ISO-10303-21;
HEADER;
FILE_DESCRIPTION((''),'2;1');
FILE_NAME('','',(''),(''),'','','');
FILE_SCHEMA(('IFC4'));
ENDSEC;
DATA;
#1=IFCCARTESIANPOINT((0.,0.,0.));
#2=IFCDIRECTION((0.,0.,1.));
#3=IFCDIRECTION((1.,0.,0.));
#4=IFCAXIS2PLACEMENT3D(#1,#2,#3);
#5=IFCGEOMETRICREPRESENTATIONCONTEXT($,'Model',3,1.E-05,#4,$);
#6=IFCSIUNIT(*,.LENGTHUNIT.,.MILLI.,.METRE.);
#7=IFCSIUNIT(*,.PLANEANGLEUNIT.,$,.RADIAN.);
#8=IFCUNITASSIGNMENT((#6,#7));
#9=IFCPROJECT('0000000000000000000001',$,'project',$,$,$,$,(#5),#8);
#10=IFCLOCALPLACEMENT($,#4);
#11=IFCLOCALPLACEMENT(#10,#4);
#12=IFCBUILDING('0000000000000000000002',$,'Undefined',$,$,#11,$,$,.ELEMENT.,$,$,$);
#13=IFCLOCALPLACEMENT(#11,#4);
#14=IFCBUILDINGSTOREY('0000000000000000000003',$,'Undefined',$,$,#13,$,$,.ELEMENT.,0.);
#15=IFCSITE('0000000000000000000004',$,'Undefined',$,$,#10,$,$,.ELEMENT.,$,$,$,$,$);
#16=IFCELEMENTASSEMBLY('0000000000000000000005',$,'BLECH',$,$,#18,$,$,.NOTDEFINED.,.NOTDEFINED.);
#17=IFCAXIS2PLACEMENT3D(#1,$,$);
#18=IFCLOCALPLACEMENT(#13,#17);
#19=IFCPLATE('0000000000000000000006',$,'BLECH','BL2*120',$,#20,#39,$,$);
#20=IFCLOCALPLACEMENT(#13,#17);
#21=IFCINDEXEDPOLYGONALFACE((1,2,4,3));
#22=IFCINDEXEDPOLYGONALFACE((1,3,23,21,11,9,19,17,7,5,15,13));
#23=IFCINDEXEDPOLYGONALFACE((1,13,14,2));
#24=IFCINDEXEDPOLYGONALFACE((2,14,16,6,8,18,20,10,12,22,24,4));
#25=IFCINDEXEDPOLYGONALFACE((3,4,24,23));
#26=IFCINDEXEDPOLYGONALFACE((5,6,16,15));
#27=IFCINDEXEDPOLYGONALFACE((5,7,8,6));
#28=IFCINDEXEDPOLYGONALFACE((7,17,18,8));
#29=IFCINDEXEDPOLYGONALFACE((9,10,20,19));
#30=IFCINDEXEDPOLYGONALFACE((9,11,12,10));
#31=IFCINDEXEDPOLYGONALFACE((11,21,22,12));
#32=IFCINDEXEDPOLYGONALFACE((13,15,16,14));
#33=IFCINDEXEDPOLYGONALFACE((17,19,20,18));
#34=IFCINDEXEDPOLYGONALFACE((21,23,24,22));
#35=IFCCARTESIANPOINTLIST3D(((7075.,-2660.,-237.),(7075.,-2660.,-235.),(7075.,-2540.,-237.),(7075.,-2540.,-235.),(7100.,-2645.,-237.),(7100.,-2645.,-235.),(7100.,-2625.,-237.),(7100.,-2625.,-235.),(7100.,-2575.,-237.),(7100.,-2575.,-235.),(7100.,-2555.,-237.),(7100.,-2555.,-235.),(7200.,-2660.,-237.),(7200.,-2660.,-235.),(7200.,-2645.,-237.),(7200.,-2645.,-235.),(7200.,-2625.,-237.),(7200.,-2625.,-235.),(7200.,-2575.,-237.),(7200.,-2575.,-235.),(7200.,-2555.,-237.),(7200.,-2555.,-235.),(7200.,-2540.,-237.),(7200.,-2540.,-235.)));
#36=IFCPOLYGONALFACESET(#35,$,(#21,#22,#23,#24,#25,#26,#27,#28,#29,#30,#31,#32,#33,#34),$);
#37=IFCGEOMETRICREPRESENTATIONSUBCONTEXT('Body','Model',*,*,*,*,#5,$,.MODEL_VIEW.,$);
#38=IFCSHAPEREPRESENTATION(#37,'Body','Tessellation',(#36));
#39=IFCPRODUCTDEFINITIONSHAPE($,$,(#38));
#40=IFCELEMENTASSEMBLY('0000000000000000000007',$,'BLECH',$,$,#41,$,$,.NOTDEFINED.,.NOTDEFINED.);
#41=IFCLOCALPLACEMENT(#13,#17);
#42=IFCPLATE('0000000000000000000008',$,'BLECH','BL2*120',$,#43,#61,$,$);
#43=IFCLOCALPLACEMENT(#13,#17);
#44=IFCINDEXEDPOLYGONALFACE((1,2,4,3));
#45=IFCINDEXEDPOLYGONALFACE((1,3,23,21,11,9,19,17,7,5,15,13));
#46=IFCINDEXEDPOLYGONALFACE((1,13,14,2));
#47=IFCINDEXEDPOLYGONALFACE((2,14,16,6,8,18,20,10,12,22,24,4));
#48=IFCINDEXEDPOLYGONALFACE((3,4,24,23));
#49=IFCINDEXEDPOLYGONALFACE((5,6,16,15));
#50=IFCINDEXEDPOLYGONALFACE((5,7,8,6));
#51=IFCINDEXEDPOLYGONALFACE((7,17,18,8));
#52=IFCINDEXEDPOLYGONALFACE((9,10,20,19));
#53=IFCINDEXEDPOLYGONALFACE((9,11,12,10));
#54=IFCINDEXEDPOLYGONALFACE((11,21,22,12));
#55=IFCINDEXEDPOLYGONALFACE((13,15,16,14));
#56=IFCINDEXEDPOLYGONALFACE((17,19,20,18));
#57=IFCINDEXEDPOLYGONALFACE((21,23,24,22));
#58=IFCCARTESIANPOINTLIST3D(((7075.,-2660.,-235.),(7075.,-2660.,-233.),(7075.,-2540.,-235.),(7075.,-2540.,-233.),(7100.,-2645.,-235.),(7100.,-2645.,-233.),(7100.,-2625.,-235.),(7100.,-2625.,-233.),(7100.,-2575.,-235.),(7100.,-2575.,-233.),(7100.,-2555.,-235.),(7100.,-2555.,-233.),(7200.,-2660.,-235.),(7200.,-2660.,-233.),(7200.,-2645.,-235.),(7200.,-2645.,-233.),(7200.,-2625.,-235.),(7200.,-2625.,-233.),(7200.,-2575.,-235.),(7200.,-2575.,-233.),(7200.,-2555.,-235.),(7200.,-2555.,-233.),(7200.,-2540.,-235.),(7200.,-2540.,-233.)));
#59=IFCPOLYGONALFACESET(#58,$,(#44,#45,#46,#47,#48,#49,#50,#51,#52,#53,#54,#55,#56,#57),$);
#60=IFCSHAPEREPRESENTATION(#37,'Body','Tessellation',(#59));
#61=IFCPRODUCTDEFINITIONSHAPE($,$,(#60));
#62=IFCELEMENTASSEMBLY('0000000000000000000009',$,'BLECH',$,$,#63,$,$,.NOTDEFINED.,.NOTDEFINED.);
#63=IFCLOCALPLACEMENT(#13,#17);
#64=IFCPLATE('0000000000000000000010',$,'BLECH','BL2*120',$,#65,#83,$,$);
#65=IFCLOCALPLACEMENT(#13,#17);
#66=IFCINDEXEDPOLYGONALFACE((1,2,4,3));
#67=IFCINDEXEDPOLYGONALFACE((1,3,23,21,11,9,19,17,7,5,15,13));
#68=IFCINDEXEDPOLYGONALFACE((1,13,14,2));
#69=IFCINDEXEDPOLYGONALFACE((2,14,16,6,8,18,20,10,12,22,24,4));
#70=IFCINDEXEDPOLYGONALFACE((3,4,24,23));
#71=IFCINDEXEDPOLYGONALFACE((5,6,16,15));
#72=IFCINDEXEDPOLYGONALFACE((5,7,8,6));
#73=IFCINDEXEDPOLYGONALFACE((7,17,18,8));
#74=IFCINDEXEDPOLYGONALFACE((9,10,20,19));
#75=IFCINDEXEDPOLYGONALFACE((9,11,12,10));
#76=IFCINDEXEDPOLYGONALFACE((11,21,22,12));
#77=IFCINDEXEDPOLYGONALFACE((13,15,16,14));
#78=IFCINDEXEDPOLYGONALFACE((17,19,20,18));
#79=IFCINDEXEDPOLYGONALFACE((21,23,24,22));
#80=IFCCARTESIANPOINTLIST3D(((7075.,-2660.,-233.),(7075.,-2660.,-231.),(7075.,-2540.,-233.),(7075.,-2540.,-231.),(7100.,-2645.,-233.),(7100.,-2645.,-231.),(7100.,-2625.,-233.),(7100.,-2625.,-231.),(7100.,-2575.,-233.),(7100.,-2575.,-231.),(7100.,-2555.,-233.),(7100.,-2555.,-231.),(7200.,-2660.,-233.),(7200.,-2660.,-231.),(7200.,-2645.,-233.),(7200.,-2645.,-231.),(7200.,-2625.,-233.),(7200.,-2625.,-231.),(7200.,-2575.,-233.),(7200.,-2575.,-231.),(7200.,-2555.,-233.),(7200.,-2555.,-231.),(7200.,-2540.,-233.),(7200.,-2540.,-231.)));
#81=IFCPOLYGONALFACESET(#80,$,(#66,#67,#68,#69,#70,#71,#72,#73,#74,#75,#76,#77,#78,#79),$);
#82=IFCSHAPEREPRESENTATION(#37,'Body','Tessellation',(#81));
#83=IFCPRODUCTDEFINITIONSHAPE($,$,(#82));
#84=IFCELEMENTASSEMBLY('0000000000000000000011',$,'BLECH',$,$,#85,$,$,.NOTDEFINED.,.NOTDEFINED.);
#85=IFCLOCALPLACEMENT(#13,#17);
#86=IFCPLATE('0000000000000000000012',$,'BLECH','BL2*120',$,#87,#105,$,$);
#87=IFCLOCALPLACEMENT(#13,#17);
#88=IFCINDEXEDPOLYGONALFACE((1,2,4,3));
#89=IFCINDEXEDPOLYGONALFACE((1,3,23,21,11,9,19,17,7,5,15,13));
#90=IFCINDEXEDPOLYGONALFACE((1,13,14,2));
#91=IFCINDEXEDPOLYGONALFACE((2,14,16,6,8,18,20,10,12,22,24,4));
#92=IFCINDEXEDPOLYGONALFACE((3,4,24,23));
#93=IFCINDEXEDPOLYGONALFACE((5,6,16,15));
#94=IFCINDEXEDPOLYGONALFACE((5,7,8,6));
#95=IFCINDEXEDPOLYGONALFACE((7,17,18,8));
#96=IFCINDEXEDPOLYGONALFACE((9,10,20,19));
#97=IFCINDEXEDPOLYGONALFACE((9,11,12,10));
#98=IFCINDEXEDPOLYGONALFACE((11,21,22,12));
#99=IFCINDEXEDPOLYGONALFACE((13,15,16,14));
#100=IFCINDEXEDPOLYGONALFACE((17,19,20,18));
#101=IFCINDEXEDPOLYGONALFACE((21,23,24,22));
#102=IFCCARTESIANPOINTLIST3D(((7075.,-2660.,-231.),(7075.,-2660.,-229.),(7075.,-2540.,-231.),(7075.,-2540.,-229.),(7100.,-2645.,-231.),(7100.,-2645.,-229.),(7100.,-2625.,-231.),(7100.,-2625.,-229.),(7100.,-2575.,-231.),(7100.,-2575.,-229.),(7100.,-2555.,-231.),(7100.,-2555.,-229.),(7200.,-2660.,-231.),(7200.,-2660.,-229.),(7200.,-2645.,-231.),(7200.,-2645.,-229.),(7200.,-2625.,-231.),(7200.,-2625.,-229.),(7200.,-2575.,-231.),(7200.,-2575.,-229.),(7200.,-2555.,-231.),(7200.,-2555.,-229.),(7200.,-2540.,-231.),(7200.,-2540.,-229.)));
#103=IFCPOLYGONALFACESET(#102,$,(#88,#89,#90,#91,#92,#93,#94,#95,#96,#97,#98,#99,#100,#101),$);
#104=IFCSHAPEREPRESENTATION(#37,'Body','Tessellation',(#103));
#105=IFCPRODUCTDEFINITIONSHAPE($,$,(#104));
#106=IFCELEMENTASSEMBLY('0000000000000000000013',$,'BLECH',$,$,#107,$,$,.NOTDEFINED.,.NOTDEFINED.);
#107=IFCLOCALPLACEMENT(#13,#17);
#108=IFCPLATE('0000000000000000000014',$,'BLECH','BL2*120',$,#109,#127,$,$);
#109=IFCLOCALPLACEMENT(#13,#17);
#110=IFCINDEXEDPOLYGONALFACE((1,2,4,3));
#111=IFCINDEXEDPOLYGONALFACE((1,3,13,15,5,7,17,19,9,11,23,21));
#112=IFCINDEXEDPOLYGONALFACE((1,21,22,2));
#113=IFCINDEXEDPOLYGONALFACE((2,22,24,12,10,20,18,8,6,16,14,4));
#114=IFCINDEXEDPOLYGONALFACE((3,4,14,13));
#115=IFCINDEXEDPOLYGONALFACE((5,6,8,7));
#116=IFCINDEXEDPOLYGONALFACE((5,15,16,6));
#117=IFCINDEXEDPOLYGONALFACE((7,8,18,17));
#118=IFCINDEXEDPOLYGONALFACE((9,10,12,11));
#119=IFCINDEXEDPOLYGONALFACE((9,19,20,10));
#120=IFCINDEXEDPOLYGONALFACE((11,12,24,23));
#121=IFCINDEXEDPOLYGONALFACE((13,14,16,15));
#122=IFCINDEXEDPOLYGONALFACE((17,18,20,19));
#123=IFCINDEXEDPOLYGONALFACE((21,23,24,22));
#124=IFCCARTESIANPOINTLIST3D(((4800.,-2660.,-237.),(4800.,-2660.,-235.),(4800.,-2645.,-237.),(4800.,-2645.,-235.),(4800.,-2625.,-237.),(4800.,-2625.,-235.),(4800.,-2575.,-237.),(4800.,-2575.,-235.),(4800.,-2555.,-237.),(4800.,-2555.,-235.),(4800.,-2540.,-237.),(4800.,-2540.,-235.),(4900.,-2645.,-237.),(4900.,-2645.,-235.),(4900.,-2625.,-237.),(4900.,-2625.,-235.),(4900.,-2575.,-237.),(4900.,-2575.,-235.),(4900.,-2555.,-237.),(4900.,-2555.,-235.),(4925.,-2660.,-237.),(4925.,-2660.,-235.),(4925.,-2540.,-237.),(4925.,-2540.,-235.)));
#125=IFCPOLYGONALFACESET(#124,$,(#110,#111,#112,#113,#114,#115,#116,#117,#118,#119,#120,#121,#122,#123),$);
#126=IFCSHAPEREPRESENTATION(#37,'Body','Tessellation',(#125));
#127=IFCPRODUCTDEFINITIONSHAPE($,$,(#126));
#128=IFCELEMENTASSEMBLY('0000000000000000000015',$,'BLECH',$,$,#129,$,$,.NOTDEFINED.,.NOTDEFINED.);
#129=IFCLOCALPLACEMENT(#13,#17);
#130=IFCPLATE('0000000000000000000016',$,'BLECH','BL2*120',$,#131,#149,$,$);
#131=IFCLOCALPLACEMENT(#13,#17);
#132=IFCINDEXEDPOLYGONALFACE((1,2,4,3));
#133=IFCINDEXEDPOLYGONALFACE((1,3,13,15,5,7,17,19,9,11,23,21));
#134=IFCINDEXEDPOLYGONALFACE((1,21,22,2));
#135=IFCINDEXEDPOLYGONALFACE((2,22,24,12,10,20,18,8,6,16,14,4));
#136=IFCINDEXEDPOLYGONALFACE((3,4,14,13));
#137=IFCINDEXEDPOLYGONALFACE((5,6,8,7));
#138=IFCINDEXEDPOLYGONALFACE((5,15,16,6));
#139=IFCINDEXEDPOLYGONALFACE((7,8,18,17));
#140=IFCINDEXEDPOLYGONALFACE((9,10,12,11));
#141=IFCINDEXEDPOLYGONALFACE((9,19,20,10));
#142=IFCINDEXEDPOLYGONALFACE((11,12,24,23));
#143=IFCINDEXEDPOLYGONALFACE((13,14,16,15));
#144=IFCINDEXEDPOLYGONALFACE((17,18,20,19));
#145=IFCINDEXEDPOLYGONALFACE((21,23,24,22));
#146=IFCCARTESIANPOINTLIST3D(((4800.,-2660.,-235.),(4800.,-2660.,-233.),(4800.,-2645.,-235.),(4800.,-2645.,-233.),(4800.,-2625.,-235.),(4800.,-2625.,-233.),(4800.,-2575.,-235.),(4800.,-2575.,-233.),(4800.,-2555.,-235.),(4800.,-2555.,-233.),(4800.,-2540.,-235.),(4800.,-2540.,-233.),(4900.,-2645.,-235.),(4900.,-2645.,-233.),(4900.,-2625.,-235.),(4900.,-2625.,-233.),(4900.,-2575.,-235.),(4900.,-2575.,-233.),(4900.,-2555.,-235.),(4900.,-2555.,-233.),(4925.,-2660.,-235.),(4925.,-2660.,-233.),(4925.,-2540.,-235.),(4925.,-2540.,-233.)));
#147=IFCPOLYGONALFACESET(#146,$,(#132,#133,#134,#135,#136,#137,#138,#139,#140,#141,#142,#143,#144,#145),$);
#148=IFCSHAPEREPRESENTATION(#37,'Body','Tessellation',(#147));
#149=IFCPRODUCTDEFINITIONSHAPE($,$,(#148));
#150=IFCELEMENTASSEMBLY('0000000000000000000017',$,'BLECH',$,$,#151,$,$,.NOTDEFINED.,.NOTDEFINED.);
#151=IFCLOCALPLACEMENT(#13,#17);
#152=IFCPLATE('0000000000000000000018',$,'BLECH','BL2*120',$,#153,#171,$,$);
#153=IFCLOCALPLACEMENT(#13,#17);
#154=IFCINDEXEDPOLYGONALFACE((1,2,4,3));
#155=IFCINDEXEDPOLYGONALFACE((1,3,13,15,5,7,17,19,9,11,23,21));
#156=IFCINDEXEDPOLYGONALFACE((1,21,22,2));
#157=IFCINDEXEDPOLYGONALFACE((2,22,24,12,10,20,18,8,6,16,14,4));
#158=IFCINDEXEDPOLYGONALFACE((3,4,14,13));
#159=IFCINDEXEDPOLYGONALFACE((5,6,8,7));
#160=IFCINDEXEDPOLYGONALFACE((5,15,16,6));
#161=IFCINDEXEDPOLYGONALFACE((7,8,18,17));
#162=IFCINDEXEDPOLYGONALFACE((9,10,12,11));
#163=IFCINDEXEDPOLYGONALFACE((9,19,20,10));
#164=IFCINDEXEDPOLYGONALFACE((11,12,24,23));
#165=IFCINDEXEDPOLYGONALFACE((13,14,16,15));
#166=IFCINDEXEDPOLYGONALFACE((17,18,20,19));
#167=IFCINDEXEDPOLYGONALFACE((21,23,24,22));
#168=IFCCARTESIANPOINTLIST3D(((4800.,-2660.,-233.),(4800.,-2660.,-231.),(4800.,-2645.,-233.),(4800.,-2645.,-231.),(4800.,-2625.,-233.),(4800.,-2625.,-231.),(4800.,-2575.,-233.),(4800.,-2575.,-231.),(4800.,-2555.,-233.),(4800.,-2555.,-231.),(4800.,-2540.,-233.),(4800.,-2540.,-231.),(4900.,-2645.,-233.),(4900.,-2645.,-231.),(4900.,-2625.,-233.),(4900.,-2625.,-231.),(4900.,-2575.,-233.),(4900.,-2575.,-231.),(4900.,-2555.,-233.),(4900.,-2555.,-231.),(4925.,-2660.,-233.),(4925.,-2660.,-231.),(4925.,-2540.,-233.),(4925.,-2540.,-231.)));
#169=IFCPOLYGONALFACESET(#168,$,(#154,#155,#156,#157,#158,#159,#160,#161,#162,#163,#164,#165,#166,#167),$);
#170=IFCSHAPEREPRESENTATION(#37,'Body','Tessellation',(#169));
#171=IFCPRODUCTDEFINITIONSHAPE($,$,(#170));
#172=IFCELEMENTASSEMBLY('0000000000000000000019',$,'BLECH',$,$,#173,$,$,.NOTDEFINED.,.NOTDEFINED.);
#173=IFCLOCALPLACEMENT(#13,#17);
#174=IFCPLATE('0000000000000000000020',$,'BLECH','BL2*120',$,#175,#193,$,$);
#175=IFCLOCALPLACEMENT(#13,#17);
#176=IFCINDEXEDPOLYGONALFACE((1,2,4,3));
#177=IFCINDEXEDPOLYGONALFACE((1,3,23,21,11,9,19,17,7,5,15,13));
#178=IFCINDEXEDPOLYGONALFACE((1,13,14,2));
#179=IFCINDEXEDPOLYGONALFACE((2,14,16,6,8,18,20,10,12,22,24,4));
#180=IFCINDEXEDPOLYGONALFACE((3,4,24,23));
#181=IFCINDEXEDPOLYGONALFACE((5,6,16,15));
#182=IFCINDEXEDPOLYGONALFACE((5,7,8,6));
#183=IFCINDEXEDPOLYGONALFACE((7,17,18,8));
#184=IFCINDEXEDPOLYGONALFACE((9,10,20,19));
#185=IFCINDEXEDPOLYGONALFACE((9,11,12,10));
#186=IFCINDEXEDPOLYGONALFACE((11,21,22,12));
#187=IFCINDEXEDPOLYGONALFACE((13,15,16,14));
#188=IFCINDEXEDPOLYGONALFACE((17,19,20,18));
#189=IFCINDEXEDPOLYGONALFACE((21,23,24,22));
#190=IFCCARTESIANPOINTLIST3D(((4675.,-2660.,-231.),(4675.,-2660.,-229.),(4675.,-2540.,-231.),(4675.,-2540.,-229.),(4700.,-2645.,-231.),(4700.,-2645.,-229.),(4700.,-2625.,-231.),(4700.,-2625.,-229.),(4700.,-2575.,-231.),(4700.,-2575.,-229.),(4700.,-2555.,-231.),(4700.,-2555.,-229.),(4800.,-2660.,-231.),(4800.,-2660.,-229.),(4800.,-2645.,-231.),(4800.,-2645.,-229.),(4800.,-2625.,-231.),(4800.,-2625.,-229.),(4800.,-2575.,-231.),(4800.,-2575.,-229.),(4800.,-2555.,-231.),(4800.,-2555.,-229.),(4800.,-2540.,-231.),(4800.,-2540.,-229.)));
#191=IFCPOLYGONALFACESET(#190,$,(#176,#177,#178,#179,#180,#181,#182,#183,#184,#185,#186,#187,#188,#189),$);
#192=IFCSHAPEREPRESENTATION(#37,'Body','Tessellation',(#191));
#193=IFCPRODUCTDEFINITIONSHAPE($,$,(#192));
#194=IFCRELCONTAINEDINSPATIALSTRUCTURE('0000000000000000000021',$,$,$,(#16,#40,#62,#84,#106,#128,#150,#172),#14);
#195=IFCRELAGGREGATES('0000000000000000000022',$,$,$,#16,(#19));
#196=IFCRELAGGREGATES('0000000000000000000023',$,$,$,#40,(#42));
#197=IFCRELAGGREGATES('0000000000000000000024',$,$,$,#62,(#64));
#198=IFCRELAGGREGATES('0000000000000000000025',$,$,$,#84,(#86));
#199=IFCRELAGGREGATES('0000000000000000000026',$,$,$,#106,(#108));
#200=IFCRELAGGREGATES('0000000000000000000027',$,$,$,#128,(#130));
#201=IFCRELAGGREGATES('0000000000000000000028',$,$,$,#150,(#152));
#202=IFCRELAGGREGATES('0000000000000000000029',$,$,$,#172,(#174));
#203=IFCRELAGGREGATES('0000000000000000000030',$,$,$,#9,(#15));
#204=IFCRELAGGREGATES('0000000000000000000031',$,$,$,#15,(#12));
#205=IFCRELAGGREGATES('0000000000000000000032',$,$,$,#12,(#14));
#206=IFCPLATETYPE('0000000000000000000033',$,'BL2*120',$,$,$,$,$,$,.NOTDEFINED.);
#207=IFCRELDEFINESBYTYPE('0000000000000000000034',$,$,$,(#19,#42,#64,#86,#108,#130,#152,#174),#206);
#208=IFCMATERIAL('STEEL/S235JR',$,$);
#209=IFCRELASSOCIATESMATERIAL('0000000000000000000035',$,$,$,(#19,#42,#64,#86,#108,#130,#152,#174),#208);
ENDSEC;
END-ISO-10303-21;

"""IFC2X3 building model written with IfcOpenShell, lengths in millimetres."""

from ifc_helpers import new_model, si_unit, frame, origin_with_axes, place, context, subcontext, project, spatial, polyline, outline, extrude, material, type_object, element, aggregate, save


model = new_model("IFC2X3")

# Units and contexts
model_context = context("Model", 3, precision=1e-05, world=origin_with_axes())
body_context = subcontext(model_context, "Body", "Model", "MODEL_VIEW")
ifc_project = project(units=[si_unit("LENGTHUNIT", "METRE", prefix="MILLI"), si_unit("PLANEANGLEUNIT", "RADIAN")], contexts=[model_context])

# Site, building, storey
site_placement = place(None, origin_with_axes())
site = spatial("IfcSite", under=ifc_project, at=site_placement, Name="Undefined", CompositionType="ELEMENT")
building_placement = place(site_placement, origin_with_axes())
building = spatial("IfcBuilding", under=site, at=building_placement, Name="Undefined", CompositionType="ELEMENT")
storey_placement = place(building_placement, origin_with_axes())
storey = spatial("IfcBuildingStorey", under=building, at=storey_placement, Name="Undefined", CompositionType="ELEMENT", Elevation=0.0)

# Shared definitions
ifc_material = material(Name="STEEL/S235JR")

# Element assemblies, plates
assembly_1_placement = place(storey_placement, origin_with_axes())
assembly_1 = element("IfcElementAssembly", 1, at=assembly_1_placement, inside=storey, Name="BLECH", AssemblyPlace="NOTDEFINED", PredefinedType="NOTDEFINED")
plate_type_1 = type_object("IfcPlateType", Name="BL2*120", PredefinedType="NOTDEFINED")
plate_1_placement = place(assembly_1_placement, frame((7075.0, -2540.0, -236.0), z_axis=(0.0, 0.0, -1.0), x_axis=(1.0, 0.0, 0.0)))
plate_1 = element("IfcPlate", 2, at=plate_1_placement, type_object=plate_type_1, material=ifc_material, Name="BLECH", Description="BL2*120", context=body_context, shape_type="SweptSolid", body=[
    extrude(outline(polyline([(0.0, 0.0), (125.0, 0.0), (125.0, 15.0), (25.0, 15.0), (25.0, 35.0), (125.0, 35.0), (125.0, 85.0), (25.0, 85.0), (25.0, 105.0), (125.0, 105.0), (125.0, 120.0), (0.0, 120.0), (0.0, 0.0)])), frame((0.0, 0.0, -1.0), z_axis=(0.0, 0.0, 1.0), x_axis=(1.0, 0.0, 0.0)), (0.0, 0.0, 1.0), 2.0),
])
aggregate(assembly_1, [plate_1])
assembly_2_placement = place(storey_placement, origin_with_axes())
assembly_2 = element("IfcElementAssembly", 3, at=assembly_2_placement, inside=storey, Name="BLECH", AssemblyPlace="NOTDEFINED", PredefinedType="NOTDEFINED")
plate_2_placement = place(assembly_2_placement, frame((7075.0, -2540.0, -234.0), z_axis=(0.0, 0.0, -1.0), x_axis=(1.0, 0.0, 0.0)))
plate_2 = element("IfcPlate", 4, at=plate_2_placement, type_object=plate_type_1, material=ifc_material, Name="BLECH", Description="BL2*120", context=body_context, shape_type="SweptSolid", body=[
    extrude(outline(polyline([(0.0, 0.0), (125.0, 0.0), (125.0, 15.0), (25.0, 15.0), (25.0, 35.0), (125.0, 35.0), (125.0, 85.0), (25.0, 85.0), (25.0, 105.0), (125.0, 105.0), (125.0, 120.0), (0.0, 120.0), (0.0, 0.0)])), frame((0.0, 0.0, -1.0), z_axis=(0.0, 0.0, 1.0), x_axis=(1.0, 0.0, 0.0)), (0.0, 0.0, 1.0), 2.0),
])
aggregate(assembly_2, [plate_2])
assembly_3_placement = place(storey_placement, origin_with_axes())
assembly_3 = element("IfcElementAssembly", 5, at=assembly_3_placement, inside=storey, Name="BLECH", AssemblyPlace="NOTDEFINED", PredefinedType="NOTDEFINED")
plate_3_placement = place(assembly_3_placement, frame((7075.0, -2540.0, -232.0), z_axis=(0.0, 0.0, -1.0), x_axis=(1.0, 0.0, 0.0)))
plate_3 = element("IfcPlate", 6, at=plate_3_placement, type_object=plate_type_1, material=ifc_material, Name="BLECH", Description="BL2*120", context=body_context, shape_type="SweptSolid", body=[
    extrude(outline(polyline([(0.0, 0.0), (125.0, 0.0), (125.0, 15.0), (25.0, 15.0), (25.0, 35.0), (125.0, 35.0), (125.0, 85.0), (25.0, 85.0), (25.0, 105.0), (125.0, 105.0), (125.0, 120.0), (0.0, 120.0), (0.0, 0.0)])), frame((0.0, 0.0, -1.0), z_axis=(0.0, 0.0, 1.0), x_axis=(1.0, 0.0, 0.0)), (0.0, 0.0, 1.0), 2.0),
])
aggregate(assembly_3, [plate_3])
assembly_4_placement = place(storey_placement, origin_with_axes())
assembly_4 = element("IfcElementAssembly", 7, at=assembly_4_placement, inside=storey, Name="BLECH", AssemblyPlace="NOTDEFINED", PredefinedType="NOTDEFINED")
plate_4_placement = place(assembly_4_placement, frame((7075.0, -2540.0, -230.0), z_axis=(0.0, 0.0, -1.0), x_axis=(1.0, 0.0, 0.0)))
plate_4 = element("IfcPlate", 8, at=plate_4_placement, type_object=plate_type_1, material=ifc_material, Name="BLECH", Description="BL2*120", context=body_context, shape_type="SweptSolid", body=[
    extrude(outline(polyline([(0.0, 0.0), (125.0, 0.0), (125.0, 15.0), (25.0, 15.0), (25.0, 35.0), (125.0, 35.0), (125.0, 85.0), (25.0, 85.0), (25.0, 105.0), (125.0, 105.0), (125.0, 120.0), (0.0, 120.0), (0.0, 0.0)])), frame((0.0, 0.0, -1.0), z_axis=(0.0, 0.0, 1.0), x_axis=(1.0, 0.0, 0.0)), (0.0, 0.0, 1.0), 2.0),
])
aggregate(assembly_4, [plate_4])
assembly_5_placement = place(storey_placement, origin_with_axes())
assembly_5 = element("IfcElementAssembly", 9, at=assembly_5_placement, inside=storey, Name="BLECH", AssemblyPlace="NOTDEFINED", PredefinedType="NOTDEFINED")
plate_5_placement = place(assembly_5_placement, frame((4925.0, -2540.0, -236.0), z_axis=(0.0, 0.0, 1.0), x_axis=(-1.0, 0.0, 0.0)))
plate_5 = element("IfcPlate", 10, at=plate_5_placement, type_object=plate_type_1, material=ifc_material, Name="BLECH", Description="BL2*120", context=body_context, shape_type="SweptSolid", body=[
    extrude(outline(polyline([(0.0, 0.0), (125.0, 0.0), (125.0, 15.0), (25.0, 15.0), (25.0, 35.0), (125.0, 35.0), (125.0, 85.0), (25.0, 85.0), (25.0, 105.0), (125.0, 105.0), (125.0, 120.0), (0.0, 120.0), (0.0, 0.0)])), frame((0.0, 0.0, -1.0), z_axis=(0.0, 0.0, 1.0), x_axis=(1.0, 0.0, 0.0)), (0.0, 0.0, 1.0), 2.0),
])
aggregate(assembly_5, [plate_5])
assembly_6_placement = place(storey_placement, origin_with_axes())
assembly_6 = element("IfcElementAssembly", 11, at=assembly_6_placement, inside=storey, Name="BLECH", AssemblyPlace="NOTDEFINED", PredefinedType="NOTDEFINED")
plate_6_placement = place(assembly_6_placement, frame((4925.0, -2540.0, -234.0), z_axis=(0.0, 0.0, 1.0), x_axis=(-1.0, 0.0, 0.0)))
plate_6 = element("IfcPlate", 12, at=plate_6_placement, type_object=plate_type_1, material=ifc_material, Name="BLECH", Description="BL2*120", context=body_context, shape_type="SweptSolid", body=[
    extrude(outline(polyline([(0.0, 0.0), (125.0, 0.0), (125.0, 15.0), (25.0, 15.0), (25.0, 35.0), (125.0, 35.0), (125.0, 85.0), (25.0, 85.0), (25.0, 105.0), (125.0, 105.0), (125.0, 120.0), (0.0, 120.0), (0.0, 0.0)])), frame((0.0, 0.0, -1.0), z_axis=(0.0, 0.0, 1.0), x_axis=(1.0, 0.0, 0.0)), (0.0, 0.0, 1.0), 2.0),
])
aggregate(assembly_6, [plate_6])
assembly_7_placement = place(storey_placement, origin_with_axes())
assembly_7 = element("IfcElementAssembly", 13, at=assembly_7_placement, inside=storey, Name="BLECH", AssemblyPlace="NOTDEFINED", PredefinedType="NOTDEFINED")
plate_7_placement = place(assembly_7_placement, frame((4925.0, -2540.0, -232.0), z_axis=(0.0, 0.0, 1.0), x_axis=(-1.0, 0.0, 0.0)))
plate_7 = element("IfcPlate", 14, at=plate_7_placement, type_object=plate_type_1, material=ifc_material, Name="BLECH", Description="BL2*120", context=body_context, shape_type="SweptSolid", body=[
    extrude(outline(polyline([(0.0, 0.0), (125.0, 0.0), (125.0, 15.0), (25.0, 15.0), (25.0, 35.0), (125.0, 35.0), (125.0, 85.0), (25.0, 85.0), (25.0, 105.0), (125.0, 105.0), (125.0, 120.0), (0.0, 120.0), (0.0, 0.0)])), frame((0.0, 0.0, -1.0), z_axis=(0.0, 0.0, 1.0), x_axis=(1.0, 0.0, 0.0)), (0.0, 0.0, 1.0), 2.0),
])
aggregate(assembly_7, [plate_7])
assembly_8_placement = place(storey_placement, origin_with_axes())
assembly_8 = element("IfcElementAssembly", 15, at=assembly_8_placement, inside=storey, Name="BLECH", AssemblyPlace="NOTDEFINED", PredefinedType="NOTDEFINED")
plate_8_placement = place(assembly_8_placement, frame((4675.0, -2540.0, -230.0), z_axis=(0.0, 0.0, -1.0), x_axis=(1.0, 0.0, 0.0)))
plate_8 = element("IfcPlate", 16, at=plate_8_placement, type_object=plate_type_1, material=ifc_material, Name="BLECH", Description="BL2*120", context=body_context, shape_type="SweptSolid", body=[
    extrude(outline(polyline([(0.0, 0.0), (125.0, 0.0), (125.0, 15.0), (25.0, 15.0), (25.0, 35.0), (125.0, 35.0), (125.0, 85.0), (25.0, 85.0), (25.0, 105.0), (125.0, 105.0), (125.0, 120.0), (0.0, 120.0), (0.0, 0.0)])), frame((0.0, 0.0, -1.0), z_axis=(0.0, 0.0, 1.0), x_axis=(1.0, 0.0, 0.0)), (0.0, 0.0, 1.0), 2.0),
])
aggregate(assembly_8, [plate_8])

save(model, "model.ifc")
